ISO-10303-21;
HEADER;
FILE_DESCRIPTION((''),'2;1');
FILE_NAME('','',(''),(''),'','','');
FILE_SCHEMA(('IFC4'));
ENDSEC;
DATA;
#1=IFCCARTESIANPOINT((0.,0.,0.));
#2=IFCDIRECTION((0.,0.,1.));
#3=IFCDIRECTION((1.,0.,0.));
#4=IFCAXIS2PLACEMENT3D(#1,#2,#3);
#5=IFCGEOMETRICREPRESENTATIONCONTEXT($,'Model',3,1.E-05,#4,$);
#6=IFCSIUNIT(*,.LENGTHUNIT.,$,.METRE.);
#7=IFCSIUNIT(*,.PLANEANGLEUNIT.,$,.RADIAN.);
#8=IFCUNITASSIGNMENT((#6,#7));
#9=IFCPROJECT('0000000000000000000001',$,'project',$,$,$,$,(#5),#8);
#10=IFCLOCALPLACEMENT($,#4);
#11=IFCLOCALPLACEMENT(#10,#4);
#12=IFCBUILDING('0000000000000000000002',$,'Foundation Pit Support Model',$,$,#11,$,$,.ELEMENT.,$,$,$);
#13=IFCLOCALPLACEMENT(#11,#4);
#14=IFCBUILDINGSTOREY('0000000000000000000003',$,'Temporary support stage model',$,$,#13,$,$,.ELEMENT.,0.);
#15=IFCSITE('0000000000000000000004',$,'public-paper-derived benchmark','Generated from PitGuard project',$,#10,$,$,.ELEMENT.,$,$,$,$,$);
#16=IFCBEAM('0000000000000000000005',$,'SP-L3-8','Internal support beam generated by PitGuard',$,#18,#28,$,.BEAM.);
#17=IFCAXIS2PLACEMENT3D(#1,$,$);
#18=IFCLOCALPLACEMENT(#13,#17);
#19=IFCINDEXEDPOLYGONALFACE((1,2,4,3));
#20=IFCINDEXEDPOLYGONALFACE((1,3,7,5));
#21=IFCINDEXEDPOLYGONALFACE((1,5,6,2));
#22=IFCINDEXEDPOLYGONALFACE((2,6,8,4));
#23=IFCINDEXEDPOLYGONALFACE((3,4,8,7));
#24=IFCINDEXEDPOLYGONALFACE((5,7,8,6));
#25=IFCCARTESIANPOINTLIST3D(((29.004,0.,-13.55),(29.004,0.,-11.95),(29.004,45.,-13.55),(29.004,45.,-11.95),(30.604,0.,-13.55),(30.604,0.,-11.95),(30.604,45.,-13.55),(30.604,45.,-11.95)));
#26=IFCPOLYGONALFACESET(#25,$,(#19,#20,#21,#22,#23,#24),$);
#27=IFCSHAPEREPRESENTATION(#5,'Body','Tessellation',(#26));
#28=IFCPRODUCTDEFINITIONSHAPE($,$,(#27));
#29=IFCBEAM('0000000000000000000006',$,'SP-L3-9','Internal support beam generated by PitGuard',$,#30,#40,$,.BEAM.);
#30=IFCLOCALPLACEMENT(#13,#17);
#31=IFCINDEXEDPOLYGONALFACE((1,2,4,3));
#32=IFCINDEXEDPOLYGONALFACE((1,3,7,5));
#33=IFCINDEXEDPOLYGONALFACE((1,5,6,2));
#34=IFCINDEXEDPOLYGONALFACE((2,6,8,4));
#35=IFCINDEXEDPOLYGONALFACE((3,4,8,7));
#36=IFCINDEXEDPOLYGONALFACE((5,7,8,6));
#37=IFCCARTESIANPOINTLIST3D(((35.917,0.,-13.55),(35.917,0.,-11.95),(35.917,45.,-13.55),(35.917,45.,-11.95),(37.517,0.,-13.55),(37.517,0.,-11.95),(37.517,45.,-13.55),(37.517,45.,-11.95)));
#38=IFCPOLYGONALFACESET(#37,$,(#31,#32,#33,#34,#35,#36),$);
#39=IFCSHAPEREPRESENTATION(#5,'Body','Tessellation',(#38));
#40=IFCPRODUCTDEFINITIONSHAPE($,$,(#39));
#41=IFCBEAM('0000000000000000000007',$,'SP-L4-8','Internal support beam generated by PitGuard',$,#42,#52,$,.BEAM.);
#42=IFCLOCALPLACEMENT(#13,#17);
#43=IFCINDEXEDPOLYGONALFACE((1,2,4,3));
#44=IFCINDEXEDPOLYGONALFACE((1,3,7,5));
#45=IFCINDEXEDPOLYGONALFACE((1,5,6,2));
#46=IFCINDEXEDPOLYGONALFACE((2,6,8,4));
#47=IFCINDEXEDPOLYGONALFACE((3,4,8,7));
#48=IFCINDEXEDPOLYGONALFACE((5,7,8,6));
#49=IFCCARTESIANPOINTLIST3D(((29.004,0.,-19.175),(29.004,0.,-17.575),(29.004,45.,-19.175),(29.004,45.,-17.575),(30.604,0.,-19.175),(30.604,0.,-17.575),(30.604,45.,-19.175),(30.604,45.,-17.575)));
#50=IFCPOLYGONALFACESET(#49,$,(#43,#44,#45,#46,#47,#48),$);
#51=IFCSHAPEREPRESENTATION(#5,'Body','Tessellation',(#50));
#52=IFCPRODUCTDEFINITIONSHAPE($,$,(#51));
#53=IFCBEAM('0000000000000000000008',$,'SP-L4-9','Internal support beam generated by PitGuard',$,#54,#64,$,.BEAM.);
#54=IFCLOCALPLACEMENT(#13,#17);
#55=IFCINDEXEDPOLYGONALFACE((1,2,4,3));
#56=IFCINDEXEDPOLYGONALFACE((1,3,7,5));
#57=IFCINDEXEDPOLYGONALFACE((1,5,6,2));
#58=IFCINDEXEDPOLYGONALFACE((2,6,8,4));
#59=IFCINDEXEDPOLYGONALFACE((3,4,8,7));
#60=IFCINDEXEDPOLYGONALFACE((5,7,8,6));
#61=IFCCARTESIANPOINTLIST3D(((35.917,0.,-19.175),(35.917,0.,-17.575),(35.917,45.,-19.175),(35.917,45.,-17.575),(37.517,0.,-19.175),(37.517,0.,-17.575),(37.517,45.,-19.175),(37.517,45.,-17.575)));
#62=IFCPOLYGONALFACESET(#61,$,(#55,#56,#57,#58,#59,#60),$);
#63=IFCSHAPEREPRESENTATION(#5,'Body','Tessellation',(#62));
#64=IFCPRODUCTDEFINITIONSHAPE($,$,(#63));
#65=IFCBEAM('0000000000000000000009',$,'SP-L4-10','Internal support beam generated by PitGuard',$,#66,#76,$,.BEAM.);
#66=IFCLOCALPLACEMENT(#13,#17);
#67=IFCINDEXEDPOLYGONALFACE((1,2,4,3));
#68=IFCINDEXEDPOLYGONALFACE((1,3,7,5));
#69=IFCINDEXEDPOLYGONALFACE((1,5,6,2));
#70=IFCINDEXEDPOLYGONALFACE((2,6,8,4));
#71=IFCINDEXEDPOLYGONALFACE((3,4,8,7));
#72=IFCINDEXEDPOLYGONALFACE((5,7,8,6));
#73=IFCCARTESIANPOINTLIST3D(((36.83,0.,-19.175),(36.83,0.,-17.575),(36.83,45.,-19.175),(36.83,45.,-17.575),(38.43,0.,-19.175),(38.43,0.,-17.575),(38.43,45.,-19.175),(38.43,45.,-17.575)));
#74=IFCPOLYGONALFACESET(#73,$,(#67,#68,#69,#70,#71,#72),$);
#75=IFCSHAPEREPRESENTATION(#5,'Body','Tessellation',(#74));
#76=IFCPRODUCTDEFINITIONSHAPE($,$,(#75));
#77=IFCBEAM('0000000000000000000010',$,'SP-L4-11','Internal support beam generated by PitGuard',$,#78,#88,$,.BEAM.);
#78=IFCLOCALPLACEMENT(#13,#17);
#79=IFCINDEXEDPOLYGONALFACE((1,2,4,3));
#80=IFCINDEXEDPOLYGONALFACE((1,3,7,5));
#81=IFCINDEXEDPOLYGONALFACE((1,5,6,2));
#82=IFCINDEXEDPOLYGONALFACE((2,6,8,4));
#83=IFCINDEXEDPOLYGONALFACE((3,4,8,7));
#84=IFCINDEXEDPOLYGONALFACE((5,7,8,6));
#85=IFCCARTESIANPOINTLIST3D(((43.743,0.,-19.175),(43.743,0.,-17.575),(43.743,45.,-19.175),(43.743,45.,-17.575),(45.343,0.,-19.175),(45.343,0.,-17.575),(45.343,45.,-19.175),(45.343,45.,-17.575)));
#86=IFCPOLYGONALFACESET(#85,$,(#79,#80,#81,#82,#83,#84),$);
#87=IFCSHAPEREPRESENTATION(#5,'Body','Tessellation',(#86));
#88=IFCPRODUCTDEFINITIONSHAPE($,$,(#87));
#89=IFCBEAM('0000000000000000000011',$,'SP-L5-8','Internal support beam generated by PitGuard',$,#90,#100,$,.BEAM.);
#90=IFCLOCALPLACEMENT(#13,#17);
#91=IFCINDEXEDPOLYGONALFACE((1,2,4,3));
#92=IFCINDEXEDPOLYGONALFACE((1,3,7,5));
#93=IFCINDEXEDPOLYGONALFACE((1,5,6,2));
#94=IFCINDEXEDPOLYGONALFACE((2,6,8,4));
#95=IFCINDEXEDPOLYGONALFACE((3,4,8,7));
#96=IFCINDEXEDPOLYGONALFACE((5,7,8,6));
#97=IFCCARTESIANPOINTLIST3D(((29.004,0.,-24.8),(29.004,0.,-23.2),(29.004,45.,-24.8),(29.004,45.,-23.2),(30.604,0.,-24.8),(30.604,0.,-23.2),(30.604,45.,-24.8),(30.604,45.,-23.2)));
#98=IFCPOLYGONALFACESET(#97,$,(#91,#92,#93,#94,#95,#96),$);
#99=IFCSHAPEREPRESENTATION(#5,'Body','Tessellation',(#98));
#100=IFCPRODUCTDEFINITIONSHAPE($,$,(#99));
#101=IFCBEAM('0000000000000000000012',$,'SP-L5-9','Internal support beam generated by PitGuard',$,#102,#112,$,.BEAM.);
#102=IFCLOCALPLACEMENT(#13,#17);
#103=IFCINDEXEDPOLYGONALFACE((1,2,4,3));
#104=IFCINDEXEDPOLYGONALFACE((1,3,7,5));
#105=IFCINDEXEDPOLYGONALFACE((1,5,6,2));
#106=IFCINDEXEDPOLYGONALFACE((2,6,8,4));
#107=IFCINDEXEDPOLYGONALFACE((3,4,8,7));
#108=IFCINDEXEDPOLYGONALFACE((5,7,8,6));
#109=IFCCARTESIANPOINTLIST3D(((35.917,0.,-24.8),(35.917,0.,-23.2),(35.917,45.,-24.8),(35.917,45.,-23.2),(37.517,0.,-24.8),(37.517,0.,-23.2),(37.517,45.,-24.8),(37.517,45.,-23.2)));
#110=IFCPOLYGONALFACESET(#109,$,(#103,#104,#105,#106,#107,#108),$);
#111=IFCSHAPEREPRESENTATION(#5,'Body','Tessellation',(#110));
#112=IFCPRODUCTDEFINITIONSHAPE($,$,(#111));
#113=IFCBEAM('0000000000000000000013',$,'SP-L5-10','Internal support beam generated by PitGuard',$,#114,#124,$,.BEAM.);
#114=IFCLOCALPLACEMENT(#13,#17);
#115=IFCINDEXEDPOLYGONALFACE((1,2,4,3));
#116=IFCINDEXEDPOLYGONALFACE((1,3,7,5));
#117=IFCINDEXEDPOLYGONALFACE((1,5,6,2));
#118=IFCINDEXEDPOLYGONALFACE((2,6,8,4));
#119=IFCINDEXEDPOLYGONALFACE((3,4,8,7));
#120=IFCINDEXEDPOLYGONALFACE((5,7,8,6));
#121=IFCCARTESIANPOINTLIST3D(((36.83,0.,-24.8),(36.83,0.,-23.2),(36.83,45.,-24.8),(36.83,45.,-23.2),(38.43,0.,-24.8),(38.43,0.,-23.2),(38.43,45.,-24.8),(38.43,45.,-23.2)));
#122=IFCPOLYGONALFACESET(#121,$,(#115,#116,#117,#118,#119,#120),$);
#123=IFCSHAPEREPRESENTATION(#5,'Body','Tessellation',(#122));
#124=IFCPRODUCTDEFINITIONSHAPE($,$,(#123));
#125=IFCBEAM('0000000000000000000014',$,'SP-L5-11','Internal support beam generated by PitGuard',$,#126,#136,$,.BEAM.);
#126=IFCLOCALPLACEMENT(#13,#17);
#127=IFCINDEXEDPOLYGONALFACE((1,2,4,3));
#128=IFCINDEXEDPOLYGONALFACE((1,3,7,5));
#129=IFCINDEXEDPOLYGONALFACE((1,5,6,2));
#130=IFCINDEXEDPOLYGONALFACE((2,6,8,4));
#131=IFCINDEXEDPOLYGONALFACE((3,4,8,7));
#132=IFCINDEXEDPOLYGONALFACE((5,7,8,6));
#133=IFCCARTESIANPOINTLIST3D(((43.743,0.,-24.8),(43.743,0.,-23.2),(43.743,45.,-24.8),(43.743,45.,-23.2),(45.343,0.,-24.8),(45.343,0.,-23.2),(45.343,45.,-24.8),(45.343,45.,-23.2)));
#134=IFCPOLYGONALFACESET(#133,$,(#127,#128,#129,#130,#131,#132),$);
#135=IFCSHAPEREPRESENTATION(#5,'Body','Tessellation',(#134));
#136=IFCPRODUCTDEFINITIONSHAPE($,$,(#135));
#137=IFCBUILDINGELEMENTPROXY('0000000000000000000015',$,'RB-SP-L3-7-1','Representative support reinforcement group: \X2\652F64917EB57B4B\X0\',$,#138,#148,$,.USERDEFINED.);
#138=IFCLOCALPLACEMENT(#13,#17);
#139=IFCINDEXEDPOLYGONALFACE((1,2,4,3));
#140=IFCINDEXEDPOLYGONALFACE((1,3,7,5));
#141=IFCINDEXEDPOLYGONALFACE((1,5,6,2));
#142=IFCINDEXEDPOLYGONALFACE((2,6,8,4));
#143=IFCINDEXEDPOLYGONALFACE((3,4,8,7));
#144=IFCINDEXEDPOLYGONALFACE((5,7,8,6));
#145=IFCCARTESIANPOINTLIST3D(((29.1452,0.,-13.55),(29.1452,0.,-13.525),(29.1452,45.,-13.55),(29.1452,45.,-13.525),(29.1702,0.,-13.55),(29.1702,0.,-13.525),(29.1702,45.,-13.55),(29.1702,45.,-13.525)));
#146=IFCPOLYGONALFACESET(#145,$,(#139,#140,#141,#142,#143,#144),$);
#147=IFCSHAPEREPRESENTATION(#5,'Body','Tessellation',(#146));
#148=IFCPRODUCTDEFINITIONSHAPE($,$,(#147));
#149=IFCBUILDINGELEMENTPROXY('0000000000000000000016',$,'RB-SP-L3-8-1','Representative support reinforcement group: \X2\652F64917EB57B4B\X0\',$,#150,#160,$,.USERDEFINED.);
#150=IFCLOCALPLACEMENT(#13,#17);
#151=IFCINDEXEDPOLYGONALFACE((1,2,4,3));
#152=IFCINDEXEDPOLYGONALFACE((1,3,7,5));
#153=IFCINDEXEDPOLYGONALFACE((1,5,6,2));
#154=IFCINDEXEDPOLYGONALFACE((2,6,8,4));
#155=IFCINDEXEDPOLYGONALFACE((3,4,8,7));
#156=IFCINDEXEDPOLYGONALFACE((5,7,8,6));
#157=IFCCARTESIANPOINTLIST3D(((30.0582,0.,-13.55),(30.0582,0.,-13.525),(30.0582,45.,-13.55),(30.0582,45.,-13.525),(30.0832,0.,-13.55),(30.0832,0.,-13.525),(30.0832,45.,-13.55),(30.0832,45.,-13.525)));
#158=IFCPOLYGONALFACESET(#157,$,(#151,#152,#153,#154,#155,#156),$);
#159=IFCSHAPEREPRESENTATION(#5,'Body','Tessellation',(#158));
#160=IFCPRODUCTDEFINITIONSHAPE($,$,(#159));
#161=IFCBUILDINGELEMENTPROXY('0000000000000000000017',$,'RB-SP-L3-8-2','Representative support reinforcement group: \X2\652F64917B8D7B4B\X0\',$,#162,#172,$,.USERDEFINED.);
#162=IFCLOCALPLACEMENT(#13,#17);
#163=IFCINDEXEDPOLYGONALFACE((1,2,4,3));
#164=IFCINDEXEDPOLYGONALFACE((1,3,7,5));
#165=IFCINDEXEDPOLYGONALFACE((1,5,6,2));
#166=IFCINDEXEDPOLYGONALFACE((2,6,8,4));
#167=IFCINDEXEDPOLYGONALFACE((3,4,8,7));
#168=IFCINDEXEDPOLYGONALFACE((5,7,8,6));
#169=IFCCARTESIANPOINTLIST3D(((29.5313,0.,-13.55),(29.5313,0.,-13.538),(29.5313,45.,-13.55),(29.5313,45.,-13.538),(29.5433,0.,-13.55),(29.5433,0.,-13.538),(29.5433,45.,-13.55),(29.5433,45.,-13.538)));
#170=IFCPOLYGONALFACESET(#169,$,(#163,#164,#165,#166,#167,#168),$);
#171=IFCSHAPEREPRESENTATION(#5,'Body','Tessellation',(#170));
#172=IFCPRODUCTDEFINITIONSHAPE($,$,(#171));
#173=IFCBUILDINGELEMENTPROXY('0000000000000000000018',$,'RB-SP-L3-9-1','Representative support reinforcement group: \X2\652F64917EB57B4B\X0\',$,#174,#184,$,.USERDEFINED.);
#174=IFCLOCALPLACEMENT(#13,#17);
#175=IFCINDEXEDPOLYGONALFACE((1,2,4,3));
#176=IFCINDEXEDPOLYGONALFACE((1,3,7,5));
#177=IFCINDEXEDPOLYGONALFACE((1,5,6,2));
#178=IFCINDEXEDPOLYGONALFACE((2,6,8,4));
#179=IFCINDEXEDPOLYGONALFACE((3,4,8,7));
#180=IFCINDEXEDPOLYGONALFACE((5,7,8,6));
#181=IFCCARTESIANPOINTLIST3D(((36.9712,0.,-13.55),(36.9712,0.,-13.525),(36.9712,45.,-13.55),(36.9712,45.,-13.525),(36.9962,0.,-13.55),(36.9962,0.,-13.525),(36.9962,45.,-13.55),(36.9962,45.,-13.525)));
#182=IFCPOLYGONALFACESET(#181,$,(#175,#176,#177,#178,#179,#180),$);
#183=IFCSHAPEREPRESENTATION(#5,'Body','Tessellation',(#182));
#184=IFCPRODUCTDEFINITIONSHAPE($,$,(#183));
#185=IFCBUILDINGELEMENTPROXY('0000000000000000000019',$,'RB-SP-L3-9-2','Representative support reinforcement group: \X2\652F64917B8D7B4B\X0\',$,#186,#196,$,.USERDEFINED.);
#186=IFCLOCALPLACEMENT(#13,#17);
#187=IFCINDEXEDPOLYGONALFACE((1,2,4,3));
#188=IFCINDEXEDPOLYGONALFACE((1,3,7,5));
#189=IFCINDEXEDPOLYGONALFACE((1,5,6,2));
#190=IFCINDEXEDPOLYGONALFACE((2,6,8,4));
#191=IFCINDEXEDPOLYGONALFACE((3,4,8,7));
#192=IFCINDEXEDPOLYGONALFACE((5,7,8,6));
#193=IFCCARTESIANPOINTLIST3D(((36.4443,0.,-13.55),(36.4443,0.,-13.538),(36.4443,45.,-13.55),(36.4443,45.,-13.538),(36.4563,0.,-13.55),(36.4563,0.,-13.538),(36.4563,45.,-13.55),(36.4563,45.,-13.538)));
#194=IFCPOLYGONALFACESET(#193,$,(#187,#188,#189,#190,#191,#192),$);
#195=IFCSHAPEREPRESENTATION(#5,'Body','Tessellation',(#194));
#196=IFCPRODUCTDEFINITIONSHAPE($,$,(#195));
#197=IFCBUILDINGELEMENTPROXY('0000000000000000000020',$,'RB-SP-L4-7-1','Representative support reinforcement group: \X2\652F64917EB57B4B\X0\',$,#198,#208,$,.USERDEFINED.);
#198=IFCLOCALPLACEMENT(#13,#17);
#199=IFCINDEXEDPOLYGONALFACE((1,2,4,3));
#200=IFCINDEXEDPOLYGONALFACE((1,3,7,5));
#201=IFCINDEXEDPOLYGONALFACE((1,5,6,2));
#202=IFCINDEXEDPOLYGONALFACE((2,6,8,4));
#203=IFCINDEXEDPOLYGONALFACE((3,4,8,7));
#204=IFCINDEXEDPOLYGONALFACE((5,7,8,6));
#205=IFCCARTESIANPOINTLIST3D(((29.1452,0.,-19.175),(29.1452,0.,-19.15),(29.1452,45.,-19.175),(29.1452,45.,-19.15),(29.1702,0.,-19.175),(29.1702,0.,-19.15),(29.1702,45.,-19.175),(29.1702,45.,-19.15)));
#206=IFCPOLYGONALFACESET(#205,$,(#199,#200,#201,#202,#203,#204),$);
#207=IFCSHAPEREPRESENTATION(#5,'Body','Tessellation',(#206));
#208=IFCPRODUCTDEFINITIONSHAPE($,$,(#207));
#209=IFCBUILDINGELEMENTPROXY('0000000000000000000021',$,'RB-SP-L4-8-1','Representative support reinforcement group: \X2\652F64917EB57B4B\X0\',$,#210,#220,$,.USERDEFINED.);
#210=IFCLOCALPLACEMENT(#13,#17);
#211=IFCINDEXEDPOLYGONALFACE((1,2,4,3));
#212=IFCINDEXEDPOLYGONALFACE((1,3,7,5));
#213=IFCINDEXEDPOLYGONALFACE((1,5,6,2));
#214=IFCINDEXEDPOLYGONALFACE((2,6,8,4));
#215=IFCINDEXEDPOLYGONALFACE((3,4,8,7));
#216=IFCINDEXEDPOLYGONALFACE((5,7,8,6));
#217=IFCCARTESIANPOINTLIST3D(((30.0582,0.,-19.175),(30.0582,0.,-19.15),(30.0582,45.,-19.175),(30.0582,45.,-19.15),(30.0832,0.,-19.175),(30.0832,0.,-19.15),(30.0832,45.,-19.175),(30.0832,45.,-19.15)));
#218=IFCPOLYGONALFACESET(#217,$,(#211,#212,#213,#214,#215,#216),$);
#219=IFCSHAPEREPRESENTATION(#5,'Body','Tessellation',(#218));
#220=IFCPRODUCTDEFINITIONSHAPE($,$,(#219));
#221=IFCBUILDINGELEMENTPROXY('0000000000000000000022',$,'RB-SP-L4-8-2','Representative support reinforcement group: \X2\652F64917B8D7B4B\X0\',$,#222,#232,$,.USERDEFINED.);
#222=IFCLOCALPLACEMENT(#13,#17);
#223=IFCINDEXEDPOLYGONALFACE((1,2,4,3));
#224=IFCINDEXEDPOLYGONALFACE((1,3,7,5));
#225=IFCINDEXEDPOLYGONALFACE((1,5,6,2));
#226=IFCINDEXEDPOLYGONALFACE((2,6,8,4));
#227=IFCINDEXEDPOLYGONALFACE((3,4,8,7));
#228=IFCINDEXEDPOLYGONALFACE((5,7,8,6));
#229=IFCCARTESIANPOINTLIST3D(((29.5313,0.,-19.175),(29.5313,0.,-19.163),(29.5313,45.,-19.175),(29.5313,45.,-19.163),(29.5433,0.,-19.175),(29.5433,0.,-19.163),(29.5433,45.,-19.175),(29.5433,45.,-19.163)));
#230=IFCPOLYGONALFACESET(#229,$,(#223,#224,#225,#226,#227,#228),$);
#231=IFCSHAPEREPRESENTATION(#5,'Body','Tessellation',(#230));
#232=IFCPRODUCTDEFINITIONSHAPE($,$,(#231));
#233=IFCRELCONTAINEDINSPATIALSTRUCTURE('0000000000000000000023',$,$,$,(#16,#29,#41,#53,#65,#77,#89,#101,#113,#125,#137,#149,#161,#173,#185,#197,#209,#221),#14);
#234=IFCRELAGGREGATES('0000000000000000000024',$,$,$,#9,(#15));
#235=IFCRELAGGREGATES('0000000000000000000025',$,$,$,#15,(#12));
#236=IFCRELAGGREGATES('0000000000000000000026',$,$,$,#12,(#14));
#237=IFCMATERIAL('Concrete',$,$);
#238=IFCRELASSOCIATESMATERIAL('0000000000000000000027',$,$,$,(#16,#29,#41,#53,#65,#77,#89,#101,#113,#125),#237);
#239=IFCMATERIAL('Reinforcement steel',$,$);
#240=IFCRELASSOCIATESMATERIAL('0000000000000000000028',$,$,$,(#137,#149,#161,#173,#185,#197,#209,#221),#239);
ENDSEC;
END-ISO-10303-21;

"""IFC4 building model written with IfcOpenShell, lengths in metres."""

from ifc_helpers import new_model, si_unit, frame, origin_with_axes, origin_2d, place, context, project, spatial, rectangle, extrude, material, element, save


model = new_model("IFC4")

# Units and contexts
model_context = context("Model", 3, precision=1e-05, world=origin_with_axes())
ifc_project = project(units=[si_unit("LENGTHUNIT", "METRE"), si_unit("PLANEANGLEUNIT", "RADIAN")], contexts=[model_context])

# Site, building, storey
site_placement = place(None, origin_with_axes())
site = spatial("IfcSite", under=ifc_project, at=site_placement, Name="public-paper-derived benchmark", Description="Generated from PitGuard project", CompositionType="ELEMENT")
building_placement = place(site_placement, origin_with_axes())
building = spatial("IfcBuilding", under=site, at=building_placement, Name="Foundation Pit Support Model", CompositionType="ELEMENT")
storey_placement = place(building_placement, origin_with_axes())
storey = spatial("IfcBuildingStorey", under=building, at=storey_placement, Name="Temporary support stage model", CompositionType="ELEMENT", Elevation=0.0)

# Beams
ifc_material_1 = material(Name="Concrete")
for number, where, z_axis, x_axis, name in (
    (1, (29.804, 22.5, -13.55), (0.0, 0.0, 1.0), (0.0, 1.0, 0.0), "SP-L3-8"),
    (2, (36.717, 22.5, -13.55), (0.0, 0.0, 1.0), (0.0, 1.0, 0.0), "SP-L3-9"),
    (3, (29.804, 22.5, -19.175), (0.0, 0.0, 1.0), (0.0, 1.0, 0.0), "SP-L4-8"),
    (4, (36.717, 22.5, -19.175), (0.0, 0.0, 1.0), (0.0, 1.0, 0.0), "SP-L4-9"),
    (5, (37.63, 22.5, -19.175), (0.0, 0.0, 1.0), (0.0, 1.0, 0.0), "SP-L4-10"),
    (6, (44.543, 22.5, -19.175), (0.0, 0.0, 1.0), (0.0, 1.0, 0.0), "SP-L4-11"),
    (7, (29.804, 22.5, -24.8), (0.0, 0.0, 1.0), (0.0, 1.0, 0.0), "SP-L5-8"),
    (8, (36.717, 22.5, -24.8), (0.0, 0.0, 1.0), (0.0, 1.0, 0.0), "SP-L5-9"),
    (9, (37.63, 22.5, -24.8), (0.0, 0.0, 1.0), (0.0, 1.0, 0.0), "SP-L5-10"),
    (10, (44.543, 22.5, -24.8), (0.0, 0.0, 1.0), (0.0, 1.0, 0.0), "SP-L5-11"),
):
    element("IfcBeam", number, at=place(storey_placement, frame(where, z_axis=z_axis, x_axis=x_axis)), inside=storey, material=ifc_material_1, Name=name, Description="Internal support beam generated by PitGuard", PredefinedType="BEAM", context=model_context, shape_type="SweptSolid", body=[
        extrude(rectangle(XDim=45.0, YDim=1.6, at=origin_2d()), origin_with_axes(), (0.0, 0.0, 1.0), 1.6),
    ])

# Building element proxies
ifc_material_2 = material(Name="Reinforcement steel")
for number, where, z_axis, x_axis, name in (
    (11, (29.1577, 22.5, -13.55), (0.0, 0.0, 1.0), (0.0, 1.0, 0.0), "RB-SP-L3-7-1"),
    (12, (30.0707, 22.5, -13.55), (0.0, 0.0, 1.0), (0.0, 1.0, 0.0), "RB-SP-L3-8-1"),
):
    element("IfcBuildingElementProxy", number, at=place(storey_placement, frame(where, z_axis=z_axis, x_axis=x_axis)), inside=storey, material=ifc_material_2, Name=name, Description="Representative support reinforcement group: 支撑纵筋", PredefinedType="USERDEFINED", context=model_context, shape_type="SweptSolid", body=[
        extrude(rectangle(XDim=45.0, YDim=0.025, at=origin_2d()), origin_with_axes(), (0.0, 0.0, 1.0), 0.025),
    ])
proxy_1_placement = place(storey_placement, frame((29.5373, 22.5, -13.55), z_axis=(0.0, 0.0, 1.0), x_axis=(0.0, 1.0, 0.0)))
element("IfcBuildingElementProxy", 13, at=proxy_1_placement, inside=storey, material=ifc_material_2, Name="RB-SP-L3-8-2", Description="Representative support reinforcement group: 支撑箍筋", PredefinedType="USERDEFINED", context=model_context, shape_type="SweptSolid", body=[
    extrude(rectangle(XDim=45.0, YDim=0.012, at=origin_2d()), origin_with_axes(), (0.0, 0.0, 1.0), 0.012),
])
proxy_2_placement = place(storey_placement, frame((36.9837, 22.5, -13.55), z_axis=(0.0, 0.0, 1.0), x_axis=(0.0, 1.0, 0.0)))
element("IfcBuildingElementProxy", 14, at=proxy_2_placement, inside=storey, material=ifc_material_2, Name="RB-SP-L3-9-1", Description="Representative support reinforcement group: 支撑纵筋", PredefinedType="USERDEFINED", context=model_context, shape_type="SweptSolid", body=[
    extrude(rectangle(XDim=45.0, YDim=0.025, at=origin_2d()), origin_with_axes(), (0.0, 0.0, 1.0), 0.025),
])
proxy_3_placement = place(storey_placement, frame((36.4503, 22.5, -13.55), z_axis=(0.0, 0.0, 1.0), x_axis=(0.0, 1.0, 0.0)))
element("IfcBuildingElementProxy", 15, at=proxy_3_placement, inside=storey, material=ifc_material_2, Name="RB-SP-L3-9-2", Description="Representative support reinforcement group: 支撑箍筋", PredefinedType="USERDEFINED", context=model_context, shape_type="SweptSolid", body=[
    extrude(rectangle(XDim=45.0, YDim=0.012, at=origin_2d()), origin_with_axes(), (0.0, 0.0, 1.0), 0.012),
])
for number, where, z_axis, x_axis, name in (
    (16, (29.1577, 22.5, -19.175), (0.0, 0.0, 1.0), (0.0, 1.0, 0.0), "RB-SP-L4-7-1"),
    (17, (30.0707, 22.5, -19.175), (0.0, 0.0, 1.0), (0.0, 1.0, 0.0), "RB-SP-L4-8-1"),
):
    element("IfcBuildingElementProxy", number, at=place(storey_placement, frame(where, z_axis=z_axis, x_axis=x_axis)), inside=storey, material=ifc_material_2, Name=name, Description="Representative support reinforcement group: 支撑纵筋", PredefinedType="USERDEFINED", context=model_context, shape_type="SweptSolid", body=[
        extrude(rectangle(XDim=45.0, YDim=0.025, at=origin_2d()), origin_with_axes(), (0.0, 0.0, 1.0), 0.025),
    ])
proxy_4_placement = place(storey_placement, frame((29.5373, 22.5, -19.175), z_axis=(0.0, 0.0, 1.0), x_axis=(0.0, 1.0, 0.0)))
element("IfcBuildingElementProxy", 18, at=proxy_4_placement, inside=storey, material=ifc_material_2, Name="RB-SP-L4-8-2", Description="Representative support reinforcement group: 支撑箍筋", PredefinedType="USERDEFINED", context=model_context, shape_type="SweptSolid", body=[
    extrude(rectangle(XDim=45.0, YDim=0.012, at=origin_2d()), origin_with_axes(), (0.0, 0.0, 1.0), 0.012),
])

save(model, "model.ifc")
